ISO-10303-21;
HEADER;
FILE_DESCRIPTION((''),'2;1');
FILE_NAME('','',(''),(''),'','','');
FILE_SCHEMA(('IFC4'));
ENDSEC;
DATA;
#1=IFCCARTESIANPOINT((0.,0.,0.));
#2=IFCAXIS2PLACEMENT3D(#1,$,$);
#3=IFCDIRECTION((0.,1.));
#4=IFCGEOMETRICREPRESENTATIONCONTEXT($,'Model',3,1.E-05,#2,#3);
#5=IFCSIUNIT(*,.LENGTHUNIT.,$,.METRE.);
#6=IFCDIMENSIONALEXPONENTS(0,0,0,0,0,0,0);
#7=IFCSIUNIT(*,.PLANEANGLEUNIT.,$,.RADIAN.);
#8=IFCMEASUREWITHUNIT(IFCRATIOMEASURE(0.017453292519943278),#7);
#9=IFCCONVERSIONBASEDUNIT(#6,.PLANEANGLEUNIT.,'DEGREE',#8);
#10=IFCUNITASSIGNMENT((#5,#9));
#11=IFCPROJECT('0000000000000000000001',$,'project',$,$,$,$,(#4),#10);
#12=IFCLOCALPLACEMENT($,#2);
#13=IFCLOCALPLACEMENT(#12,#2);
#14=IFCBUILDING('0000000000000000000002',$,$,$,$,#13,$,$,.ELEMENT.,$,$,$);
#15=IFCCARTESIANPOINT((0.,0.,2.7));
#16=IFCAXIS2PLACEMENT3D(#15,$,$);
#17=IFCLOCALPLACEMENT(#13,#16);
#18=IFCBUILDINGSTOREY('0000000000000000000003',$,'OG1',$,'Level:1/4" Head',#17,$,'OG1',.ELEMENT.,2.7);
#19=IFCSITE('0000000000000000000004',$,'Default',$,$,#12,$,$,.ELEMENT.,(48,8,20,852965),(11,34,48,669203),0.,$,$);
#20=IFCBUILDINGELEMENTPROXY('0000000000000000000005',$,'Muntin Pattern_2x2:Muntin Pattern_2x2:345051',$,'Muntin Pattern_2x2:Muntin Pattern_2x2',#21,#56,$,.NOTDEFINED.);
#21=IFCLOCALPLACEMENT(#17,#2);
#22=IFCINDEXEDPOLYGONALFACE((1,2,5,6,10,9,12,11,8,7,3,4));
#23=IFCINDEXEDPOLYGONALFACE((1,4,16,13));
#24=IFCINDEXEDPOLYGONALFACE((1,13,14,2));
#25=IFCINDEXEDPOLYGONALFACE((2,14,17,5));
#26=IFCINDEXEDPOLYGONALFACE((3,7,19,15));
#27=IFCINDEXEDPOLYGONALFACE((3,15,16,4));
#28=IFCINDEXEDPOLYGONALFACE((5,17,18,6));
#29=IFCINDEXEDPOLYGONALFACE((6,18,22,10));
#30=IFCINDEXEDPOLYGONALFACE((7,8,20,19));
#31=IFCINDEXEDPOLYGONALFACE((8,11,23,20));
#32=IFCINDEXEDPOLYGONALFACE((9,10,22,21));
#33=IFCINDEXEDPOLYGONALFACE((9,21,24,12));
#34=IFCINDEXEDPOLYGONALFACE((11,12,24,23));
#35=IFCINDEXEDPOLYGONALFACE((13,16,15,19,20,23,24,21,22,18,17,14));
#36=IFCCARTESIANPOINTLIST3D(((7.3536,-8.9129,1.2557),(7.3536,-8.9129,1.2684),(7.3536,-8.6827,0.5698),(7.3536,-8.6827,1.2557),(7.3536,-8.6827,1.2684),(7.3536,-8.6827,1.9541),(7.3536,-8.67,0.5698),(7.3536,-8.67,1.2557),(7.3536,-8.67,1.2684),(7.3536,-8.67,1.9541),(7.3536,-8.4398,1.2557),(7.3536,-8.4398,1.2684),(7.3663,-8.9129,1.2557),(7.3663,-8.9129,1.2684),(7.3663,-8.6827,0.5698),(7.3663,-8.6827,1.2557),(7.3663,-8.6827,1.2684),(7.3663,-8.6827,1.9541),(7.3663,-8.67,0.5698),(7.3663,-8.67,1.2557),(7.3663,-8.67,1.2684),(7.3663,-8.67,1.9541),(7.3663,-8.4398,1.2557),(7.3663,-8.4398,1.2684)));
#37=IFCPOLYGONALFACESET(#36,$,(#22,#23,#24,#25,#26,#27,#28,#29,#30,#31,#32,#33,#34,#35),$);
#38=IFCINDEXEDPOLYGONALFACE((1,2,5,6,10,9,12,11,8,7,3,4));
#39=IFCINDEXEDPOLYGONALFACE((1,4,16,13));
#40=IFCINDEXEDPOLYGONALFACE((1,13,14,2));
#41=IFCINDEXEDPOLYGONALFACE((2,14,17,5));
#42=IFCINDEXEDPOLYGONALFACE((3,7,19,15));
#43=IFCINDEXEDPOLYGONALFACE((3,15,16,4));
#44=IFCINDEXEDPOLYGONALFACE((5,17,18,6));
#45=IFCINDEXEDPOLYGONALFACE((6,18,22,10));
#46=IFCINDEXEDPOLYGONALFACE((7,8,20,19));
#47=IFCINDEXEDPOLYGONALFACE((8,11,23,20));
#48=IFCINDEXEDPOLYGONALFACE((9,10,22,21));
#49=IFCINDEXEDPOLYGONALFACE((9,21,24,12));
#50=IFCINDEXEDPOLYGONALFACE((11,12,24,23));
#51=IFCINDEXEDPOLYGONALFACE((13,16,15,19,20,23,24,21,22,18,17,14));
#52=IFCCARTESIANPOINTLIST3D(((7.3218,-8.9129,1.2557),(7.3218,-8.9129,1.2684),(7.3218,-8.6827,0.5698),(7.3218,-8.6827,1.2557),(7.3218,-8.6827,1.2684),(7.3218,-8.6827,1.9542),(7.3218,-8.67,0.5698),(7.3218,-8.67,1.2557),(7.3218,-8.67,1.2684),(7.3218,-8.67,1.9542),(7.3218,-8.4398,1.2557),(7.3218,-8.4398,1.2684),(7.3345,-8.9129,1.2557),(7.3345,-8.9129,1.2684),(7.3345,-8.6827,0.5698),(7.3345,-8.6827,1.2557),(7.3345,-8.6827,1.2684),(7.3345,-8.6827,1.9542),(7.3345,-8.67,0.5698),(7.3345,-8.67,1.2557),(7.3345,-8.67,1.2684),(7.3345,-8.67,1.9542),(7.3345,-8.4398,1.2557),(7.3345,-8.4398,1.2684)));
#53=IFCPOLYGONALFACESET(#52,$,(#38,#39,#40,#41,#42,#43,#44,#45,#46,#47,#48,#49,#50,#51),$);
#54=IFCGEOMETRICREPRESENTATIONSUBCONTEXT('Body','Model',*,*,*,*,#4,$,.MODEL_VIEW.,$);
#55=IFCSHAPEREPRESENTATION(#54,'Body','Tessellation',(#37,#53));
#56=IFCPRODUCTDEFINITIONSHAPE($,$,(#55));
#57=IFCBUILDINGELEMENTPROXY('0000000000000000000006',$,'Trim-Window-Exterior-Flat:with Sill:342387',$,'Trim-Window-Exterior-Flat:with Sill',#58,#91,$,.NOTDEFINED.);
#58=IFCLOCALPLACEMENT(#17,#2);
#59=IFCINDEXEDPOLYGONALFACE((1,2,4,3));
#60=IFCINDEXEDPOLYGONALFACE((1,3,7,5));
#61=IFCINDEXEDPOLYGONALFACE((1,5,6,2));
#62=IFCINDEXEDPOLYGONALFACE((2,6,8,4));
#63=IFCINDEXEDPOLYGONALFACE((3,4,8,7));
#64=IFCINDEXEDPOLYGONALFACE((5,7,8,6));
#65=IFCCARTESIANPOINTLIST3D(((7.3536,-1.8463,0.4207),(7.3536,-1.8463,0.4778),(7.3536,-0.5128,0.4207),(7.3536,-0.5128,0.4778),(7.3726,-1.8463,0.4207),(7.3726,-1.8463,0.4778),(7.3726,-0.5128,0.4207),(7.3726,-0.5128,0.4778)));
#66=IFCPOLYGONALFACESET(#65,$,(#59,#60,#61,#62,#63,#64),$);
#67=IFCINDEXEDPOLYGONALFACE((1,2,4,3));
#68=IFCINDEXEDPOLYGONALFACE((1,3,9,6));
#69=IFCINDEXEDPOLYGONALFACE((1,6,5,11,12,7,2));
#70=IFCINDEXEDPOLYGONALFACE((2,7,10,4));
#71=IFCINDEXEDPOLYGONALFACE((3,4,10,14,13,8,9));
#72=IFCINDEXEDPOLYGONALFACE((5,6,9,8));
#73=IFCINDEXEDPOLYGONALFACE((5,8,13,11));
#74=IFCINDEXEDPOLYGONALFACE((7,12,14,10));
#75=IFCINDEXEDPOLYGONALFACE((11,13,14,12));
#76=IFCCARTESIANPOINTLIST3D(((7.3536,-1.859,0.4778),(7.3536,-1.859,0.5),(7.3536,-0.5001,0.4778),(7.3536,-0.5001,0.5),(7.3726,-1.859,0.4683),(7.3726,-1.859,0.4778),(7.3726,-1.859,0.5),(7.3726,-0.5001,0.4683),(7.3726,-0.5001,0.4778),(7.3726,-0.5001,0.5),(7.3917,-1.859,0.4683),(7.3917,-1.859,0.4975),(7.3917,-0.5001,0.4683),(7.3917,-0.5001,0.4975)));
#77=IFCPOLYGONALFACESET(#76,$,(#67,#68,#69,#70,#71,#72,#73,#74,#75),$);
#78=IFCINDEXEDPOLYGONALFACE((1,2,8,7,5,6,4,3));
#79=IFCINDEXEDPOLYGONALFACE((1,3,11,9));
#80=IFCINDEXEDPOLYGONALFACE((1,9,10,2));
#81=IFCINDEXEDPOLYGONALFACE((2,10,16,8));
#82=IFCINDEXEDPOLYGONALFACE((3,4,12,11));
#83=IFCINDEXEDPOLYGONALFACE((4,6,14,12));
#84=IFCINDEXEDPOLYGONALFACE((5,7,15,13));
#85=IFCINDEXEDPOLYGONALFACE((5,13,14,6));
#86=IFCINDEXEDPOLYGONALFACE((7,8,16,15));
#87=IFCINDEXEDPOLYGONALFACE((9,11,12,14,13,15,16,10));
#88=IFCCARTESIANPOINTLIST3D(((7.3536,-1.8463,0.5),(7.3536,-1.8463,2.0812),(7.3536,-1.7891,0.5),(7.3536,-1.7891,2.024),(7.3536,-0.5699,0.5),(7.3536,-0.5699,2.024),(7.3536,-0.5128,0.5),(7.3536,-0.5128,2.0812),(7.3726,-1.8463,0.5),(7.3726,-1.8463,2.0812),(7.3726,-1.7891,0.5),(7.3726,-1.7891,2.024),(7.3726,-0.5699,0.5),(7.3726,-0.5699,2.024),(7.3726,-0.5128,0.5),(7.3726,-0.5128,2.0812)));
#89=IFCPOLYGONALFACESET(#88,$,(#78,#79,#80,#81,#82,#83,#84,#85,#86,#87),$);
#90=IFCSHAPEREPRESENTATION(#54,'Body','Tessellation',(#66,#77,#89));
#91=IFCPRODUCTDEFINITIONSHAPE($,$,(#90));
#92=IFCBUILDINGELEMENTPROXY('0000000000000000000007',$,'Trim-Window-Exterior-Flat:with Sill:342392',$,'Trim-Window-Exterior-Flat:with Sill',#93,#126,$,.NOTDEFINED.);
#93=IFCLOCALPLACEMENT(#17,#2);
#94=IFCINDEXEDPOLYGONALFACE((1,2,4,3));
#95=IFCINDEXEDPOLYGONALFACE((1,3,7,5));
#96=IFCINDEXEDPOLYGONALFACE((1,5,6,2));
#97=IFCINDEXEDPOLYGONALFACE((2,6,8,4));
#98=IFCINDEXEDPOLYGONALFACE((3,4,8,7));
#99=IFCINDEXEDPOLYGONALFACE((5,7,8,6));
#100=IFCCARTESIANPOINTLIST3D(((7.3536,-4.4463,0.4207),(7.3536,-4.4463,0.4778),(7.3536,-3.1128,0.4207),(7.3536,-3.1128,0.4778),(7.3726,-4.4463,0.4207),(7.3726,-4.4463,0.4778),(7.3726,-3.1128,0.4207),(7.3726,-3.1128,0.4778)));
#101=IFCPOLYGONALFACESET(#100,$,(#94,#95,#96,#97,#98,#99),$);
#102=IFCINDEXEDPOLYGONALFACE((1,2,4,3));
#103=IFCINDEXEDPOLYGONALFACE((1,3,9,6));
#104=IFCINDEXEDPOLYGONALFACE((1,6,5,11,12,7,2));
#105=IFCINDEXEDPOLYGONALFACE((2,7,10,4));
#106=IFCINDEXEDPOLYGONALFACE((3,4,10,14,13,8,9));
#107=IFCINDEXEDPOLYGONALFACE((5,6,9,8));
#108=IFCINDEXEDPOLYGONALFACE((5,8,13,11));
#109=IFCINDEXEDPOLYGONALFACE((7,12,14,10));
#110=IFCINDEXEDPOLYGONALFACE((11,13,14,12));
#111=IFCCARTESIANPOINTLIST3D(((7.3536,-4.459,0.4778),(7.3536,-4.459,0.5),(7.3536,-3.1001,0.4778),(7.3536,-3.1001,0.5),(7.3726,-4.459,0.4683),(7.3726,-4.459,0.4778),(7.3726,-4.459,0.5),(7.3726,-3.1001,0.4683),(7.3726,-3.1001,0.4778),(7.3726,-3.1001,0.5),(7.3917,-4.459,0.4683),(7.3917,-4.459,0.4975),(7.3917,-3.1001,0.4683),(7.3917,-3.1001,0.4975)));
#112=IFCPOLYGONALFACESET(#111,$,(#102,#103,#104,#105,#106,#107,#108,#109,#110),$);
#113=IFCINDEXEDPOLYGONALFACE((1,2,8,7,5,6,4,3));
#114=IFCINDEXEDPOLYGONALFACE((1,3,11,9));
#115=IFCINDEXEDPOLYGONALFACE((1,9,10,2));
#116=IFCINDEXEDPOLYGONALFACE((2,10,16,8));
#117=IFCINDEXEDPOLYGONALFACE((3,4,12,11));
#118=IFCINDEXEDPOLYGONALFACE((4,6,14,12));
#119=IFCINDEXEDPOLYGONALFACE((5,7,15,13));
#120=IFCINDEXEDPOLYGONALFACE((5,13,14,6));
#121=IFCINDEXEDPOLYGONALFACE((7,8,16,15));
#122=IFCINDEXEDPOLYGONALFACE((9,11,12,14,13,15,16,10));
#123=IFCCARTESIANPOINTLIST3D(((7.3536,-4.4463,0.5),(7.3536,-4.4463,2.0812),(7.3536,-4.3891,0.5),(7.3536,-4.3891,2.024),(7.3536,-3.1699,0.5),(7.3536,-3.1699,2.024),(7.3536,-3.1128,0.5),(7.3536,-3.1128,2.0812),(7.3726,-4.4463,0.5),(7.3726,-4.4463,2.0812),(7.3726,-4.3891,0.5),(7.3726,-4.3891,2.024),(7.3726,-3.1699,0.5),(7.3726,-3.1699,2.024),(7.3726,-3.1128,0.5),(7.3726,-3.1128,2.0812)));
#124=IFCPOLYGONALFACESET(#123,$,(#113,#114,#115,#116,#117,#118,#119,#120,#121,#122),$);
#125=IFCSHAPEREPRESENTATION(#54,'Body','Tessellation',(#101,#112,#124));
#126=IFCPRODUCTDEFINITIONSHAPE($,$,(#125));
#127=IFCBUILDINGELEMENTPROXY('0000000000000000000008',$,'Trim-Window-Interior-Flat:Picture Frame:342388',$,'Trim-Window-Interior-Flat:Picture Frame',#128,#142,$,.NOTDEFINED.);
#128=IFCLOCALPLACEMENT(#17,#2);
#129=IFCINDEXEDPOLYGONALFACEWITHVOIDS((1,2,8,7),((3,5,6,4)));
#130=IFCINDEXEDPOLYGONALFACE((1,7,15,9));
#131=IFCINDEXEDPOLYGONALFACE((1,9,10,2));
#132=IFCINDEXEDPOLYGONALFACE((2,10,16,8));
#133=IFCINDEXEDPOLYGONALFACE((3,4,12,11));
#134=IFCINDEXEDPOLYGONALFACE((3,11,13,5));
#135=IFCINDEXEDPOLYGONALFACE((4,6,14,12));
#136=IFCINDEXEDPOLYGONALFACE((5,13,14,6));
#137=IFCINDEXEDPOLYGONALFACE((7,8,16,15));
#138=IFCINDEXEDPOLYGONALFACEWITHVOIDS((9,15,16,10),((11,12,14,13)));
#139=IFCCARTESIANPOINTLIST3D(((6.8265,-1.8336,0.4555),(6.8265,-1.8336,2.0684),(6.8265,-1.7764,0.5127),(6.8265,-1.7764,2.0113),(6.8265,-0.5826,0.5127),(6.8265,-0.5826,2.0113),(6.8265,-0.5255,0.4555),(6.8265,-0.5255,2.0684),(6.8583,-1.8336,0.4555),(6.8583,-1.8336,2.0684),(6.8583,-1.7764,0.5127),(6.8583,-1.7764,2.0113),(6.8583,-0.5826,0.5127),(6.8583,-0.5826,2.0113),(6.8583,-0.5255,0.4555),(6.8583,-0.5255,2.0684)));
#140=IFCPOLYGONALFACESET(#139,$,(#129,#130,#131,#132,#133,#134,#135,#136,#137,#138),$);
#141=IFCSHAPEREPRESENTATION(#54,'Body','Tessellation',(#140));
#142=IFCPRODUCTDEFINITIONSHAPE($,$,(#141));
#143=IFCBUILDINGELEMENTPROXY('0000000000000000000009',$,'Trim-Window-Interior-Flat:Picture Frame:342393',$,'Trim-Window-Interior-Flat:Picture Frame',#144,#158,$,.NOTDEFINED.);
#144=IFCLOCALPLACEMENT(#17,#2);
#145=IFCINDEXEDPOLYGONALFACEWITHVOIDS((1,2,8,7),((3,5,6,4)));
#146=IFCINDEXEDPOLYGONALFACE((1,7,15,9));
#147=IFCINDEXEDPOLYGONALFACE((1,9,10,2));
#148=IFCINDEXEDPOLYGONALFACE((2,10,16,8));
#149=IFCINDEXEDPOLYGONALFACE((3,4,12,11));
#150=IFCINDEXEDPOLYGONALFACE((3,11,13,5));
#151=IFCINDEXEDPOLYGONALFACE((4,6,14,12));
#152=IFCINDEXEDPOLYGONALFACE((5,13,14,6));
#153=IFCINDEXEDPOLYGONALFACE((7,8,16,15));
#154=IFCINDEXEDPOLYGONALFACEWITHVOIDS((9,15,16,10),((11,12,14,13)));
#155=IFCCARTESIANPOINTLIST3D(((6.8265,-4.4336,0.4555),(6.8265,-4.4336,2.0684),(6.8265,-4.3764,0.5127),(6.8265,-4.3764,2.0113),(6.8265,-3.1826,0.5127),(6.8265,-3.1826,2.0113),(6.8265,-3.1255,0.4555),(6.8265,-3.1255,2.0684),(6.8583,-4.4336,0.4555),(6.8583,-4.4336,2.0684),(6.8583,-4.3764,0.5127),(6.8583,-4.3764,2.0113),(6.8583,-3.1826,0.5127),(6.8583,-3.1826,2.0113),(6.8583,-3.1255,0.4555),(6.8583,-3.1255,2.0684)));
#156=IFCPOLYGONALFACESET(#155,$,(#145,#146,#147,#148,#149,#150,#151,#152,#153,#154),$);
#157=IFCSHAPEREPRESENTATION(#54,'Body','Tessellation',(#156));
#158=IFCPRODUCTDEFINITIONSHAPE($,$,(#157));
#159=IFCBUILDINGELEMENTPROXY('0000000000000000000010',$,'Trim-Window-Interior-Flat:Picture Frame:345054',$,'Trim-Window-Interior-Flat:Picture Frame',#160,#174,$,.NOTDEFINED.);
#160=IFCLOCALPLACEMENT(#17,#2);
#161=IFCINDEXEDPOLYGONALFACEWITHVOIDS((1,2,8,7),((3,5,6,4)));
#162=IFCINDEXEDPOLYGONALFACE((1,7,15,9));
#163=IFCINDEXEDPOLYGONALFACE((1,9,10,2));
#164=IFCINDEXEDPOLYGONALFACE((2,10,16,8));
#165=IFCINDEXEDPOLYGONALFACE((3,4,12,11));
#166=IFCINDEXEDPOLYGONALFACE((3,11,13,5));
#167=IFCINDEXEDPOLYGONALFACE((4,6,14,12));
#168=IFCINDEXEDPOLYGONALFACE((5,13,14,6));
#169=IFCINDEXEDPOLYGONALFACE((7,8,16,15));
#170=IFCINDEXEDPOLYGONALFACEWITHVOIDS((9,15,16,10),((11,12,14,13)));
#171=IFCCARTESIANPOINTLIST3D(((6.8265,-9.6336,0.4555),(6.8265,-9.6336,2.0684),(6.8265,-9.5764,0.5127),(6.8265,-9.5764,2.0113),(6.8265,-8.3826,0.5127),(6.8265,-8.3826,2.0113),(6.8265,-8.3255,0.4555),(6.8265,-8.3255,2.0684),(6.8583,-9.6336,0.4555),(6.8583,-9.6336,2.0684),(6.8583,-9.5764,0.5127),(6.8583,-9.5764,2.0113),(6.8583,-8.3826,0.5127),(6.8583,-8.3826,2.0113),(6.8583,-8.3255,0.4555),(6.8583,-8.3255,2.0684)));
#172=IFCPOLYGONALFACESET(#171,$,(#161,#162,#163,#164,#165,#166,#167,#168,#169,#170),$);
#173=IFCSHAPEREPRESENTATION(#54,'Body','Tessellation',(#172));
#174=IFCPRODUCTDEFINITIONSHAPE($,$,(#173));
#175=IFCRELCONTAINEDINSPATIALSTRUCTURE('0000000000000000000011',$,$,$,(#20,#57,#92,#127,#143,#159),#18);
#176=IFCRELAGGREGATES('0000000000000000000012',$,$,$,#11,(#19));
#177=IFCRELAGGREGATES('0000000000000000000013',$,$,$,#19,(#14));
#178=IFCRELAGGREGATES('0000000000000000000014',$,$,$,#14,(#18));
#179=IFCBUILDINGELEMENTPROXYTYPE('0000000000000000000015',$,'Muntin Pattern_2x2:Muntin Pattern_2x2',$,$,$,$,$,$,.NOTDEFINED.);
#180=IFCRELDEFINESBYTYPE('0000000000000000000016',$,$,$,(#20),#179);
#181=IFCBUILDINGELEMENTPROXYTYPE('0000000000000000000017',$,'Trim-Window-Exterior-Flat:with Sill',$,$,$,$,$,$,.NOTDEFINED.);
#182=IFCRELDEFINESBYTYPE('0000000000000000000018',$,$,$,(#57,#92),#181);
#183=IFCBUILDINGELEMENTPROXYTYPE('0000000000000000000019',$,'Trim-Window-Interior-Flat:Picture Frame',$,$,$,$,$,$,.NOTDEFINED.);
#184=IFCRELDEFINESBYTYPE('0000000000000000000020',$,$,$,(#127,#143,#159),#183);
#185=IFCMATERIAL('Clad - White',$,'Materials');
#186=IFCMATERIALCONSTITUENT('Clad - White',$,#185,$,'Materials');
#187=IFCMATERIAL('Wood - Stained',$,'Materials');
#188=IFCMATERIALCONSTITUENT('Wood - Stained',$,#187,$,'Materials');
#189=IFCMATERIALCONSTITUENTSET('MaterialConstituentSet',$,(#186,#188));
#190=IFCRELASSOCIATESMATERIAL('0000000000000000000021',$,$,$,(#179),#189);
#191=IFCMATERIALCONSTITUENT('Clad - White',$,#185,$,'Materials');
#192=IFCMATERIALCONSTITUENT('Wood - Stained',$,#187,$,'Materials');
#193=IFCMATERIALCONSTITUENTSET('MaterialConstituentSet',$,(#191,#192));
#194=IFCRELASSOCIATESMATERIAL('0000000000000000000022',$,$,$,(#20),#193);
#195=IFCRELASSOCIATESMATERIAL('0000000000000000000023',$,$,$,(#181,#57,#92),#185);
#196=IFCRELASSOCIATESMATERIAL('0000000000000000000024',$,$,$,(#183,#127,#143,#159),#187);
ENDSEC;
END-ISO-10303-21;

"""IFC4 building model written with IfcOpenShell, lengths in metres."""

from ifc_helpers import new_model, entity, si_unit, converted_unit, direction, frame, origin, place, context, subcontext, project, spatial, indexed_curve, outline, extrude, source, transform, mapped, material, constituent, constituent_set, type_object, type_shapes, element, save


model = new_model("IFC4")

# Units and contexts
model_context = context("Model", 3, precision=1e-05, world=origin(), true_north=direction((0.0, 1.0)))
body_context = subcontext(model_context, "Body", "Model", "MODEL_VIEW")
ifc_project = project(units=[si_unit("LENGTHUNIT", "METRE"), converted_unit("PLANEANGLEUNIT", "DEGREE", entity("IfcRatioMeasure", 0.017453292519943278), si_unit("PLANEANGLEUNIT", "RADIAN"), dimensions=[0, 0, 0, 0, 0, 0, 0])], contexts=[model_context])

# Site, building, storey
site_placement = place(None, origin())
site = spatial("IfcSite", under=ifc_project, at=site_placement, Name="Default", CompositionType="ELEMENT", RefLatitude=(48, 8, 20, 852965), RefLongitude=(11, 34, 48, 669203), RefElevation=0.0)
building_placement = place(site_placement, origin())
building = spatial("IfcBuilding", under=site, at=building_placement, CompositionType="ELEMENT")
storey_placement = place(building_placement, frame((0.0, 0.0, 2.7)))
storey = spatial("IfcBuildingStorey", under=building, at=storey_placement, Name="OG1", ObjectType="Level:1/4\" Head", LongName="OG1", CompositionType="ELEMENT", Elevation=2.7)

# Building element proxies
ifc_material_1 = material(Name="Clad - White", Category="Materials")
ifc_material_2 = material(Name="Wood - Stained", Category="Materials")
ifc_constituent_1 = constituent(ifc_material_1, Name="Clad - White", Category="Materials")
ifc_constituent_2 = constituent(ifc_material_2, Name="Wood - Stained", Category="Materials")
ifc_constituent_set_1 = constituent_set(constituents=[ifc_constituent_1, ifc_constituent_2], Name="MaterialConstituentSet")
building_element_proxy_type_1 = type_object("IfcBuildingElementProxyType", Name="Muntin Pattern_2x2:Muntin Pattern_2x2", PredefinedType="NOTDEFINED", material=ifc_constituent_set_1)
shared_shape_1 = source(origin(), body_context, "Body", "SweptSolid", [
    extrude(outline(indexed_curve([(0.0064, -0.0064), (0.6921, -0.0064), (0.6921, 0.0063), (0.0064, 0.0063), (0.0064, 0.2365), (-0.0063, 0.2365), (-0.0063, 0.0063), (-0.6922, 0.0063), (-0.6922, -0.0064), (-0.0063, -0.0064), (-0.0063, -0.2365), (0.0064, -0.2365), (0.0064, -0.0064)], self_intersect=False)), frame((0.0, 0.0095, 0.6921), z_axis=(0.0, 1.0, 0.0), x_axis=(0.0, 0.0, 1.0)), (0.0, 0.0, 1.0), 0.0127),
    extrude(outline(indexed_curve([(0.0064, -0.0064), (0.6922, -0.0064), (0.6922, 0.0063), (0.0064, 0.0063), (0.0064, 0.2365), (-0.0063, 0.2365), (-0.0063, 0.0063), (-0.6922, 0.0063), (-0.6922, -0.0064), (-0.0063, -0.0064), (-0.0063, -0.2365), (0.0064, -0.2365), (0.0064, -0.0064)], self_intersect=False)), frame((0.0, -0.0222, 0.6922), z_axis=(0.0, 1.0, 0.0), x_axis=(0.0, 0.0, 1.0)), (0.0, 0.0, 1.0), 0.0127),
])
type_shapes(building_element_proxy_type_1, [shared_shape_1])
ifc_constituent_3 = constituent(ifc_material_1, Name="Clad - White", Category="Materials")
ifc_constituent_4 = constituent(ifc_material_2, Name="Wood - Stained", Category="Materials")
ifc_constituent_set_2 = constituent_set(constituents=[ifc_constituent_3, ifc_constituent_4], Name="MaterialConstituentSet")
proxy_1_placement = place(storey_placement, frame((7.3441, -8.6763, 0.5699), z_axis=(0.0, 0.0, 1.0), x_axis=(0.0, -1.0, 0.0)))
element("IfcBuildingElementProxy", 1, at=proxy_1_placement, inside=storey, type_object=building_element_proxy_type_1, material=ifc_constituent_set_2, Name="Muntin Pattern_2x2:Muntin Pattern_2x2:345051", ObjectType="Muntin Pattern_2x2:Muntin Pattern_2x2", PredefinedType="NOTDEFINED", context=body_context, shape_type="MappedRepresentation", body=[
    mapped(shared_shape_1, transform((0.0, 0.0, 0.0), scale=1.0)),
])
building_element_proxy_type_2 = type_object("IfcBuildingElementProxyType", Name="Trim-Window-Exterior-Flat:with Sill", PredefinedType="NOTDEFINED", material=ifc_material_1)
shared_shape_2 = source(origin(), body_context, "Body", "SweptSolid", [
    extrude(outline(indexed_curve([(-0.6667, -0.0286), (0.6667, -0.0286), (0.6667, 0.0286), (-0.6667, 0.0286), (-0.6667, -0.0286)], self_intersect=False)), frame((0.0, -1.5748, 0.0), z_axis=(0.0, 0.0, 1.0), x_axis=(-1.0, 0.0, 0.0)), (0.0, 0.0, 1.0), 0.019),
    extrude(outline(indexed_curve([(-0.019, -0.016), (0.0, -0.016), (0.0, -0.0064), (0.019, -0.0064), (0.019, 0.0158), (0.0, 0.0158), (-0.019, 0.0133), (-0.019, -0.016)], self_intersect=False)), frame((-0.6794, -1.5398, 0.019), z_axis=(1.0, 0.0, 0.0), x_axis=(0.0, 0.0, -1.0)), (0.0, 0.0, 1.0), 1.3589),
    extrude(outline(indexed_curve([(-0.8049, -0.6667), (0.7763, -0.6667), (0.7763, -0.6096), (-0.7477, -0.6096), (-0.7477, 0.6096), (0.7763, 0.6096), (0.7763, 0.6667), (-0.8049, 0.6667), (-0.8049, -0.6667)], self_intersect=False)), frame((0.0, -0.7477, 0.0), z_axis=(0.0, 0.0, 1.0), x_axis=(0.0, -1.0, 0.0)), (0.0, 0.0, 1.0), 0.019),
])
type_shapes(building_element_proxy_type_2, [shared_shape_2])
for number, where, z_axis, x_axis, name in (
    (2, (7.3536, -1.1795, 2.024), (1.0, 0.0, 0.0), (0.0, 1.0, 0.0), "Trim-Window-Exterior-Flat:with Sill:342387"),
    (3, (7.3536, -3.7795, 2.024), (1.0, 0.0, 0.0), (0.0, 1.0, 0.0), "Trim-Window-Exterior-Flat:with Sill:342392"),
):
    element("IfcBuildingElementProxy", number, at=place(storey_placement, frame(where, z_axis=z_axis, x_axis=x_axis)), inside=storey, type_object=building_element_proxy_type_2, material=ifc_material_1, Name=name, ObjectType="Trim-Window-Exterior-Flat:with Sill", PredefinedType="NOTDEFINED", context=body_context, shape_type="MappedRepresentation", body=[
        mapped(shared_shape_2, transform((0.0, 0.0, 0.0), scale=1.0)),
    ])
building_element_proxy_type_3 = type_object("IfcBuildingElementProxyType", Name="Trim-Window-Interior-Flat:Picture Frame", PredefinedType="NOTDEFINED", material=ifc_material_2)
shared_shape_3 = source(origin(), body_context, "Body", "SweptSolid", [
    extrude(outline(indexed_curve([(-0.654, -0.8064), (0.654, -0.8064), (0.654, 0.8064), (-0.654, 0.8064), (-0.654, -0.8064)], self_intersect=False), holes=[indexed_curve([(-0.5969, -0.7493), (-0.5969, 0.7493), (0.5969, 0.7493), (0.5969, -0.7493), (-0.5969, -0.7493)], self_intersect=False)]), frame((0.0, -0.762, 0.0), z_axis=(0.0, 0.0, 1.0), x_axis=(-1.0, 0.0, 0.0)), (0.0, 0.0, 1.0), 0.0317),
])
type_shapes(building_element_proxy_type_3, [shared_shape_3])
for number, where, z_axis, x_axis, name in (
    (4, (6.8583, -1.1795, 2.024), (-1.0, 0.0, 0.0), (0.0, -1.0, 0.0), "Trim-Window-Interior-Flat:Picture Frame:342388"),
    (5, (6.8583, -3.7795, 2.024), (-1.0, 0.0, 0.0), (0.0, -1.0, 0.0), "Trim-Window-Interior-Flat:Picture Frame:342393"),
    (6, (6.8583, -8.9795, 2.024), (-1.0, 0.0, 0.0), (0.0, -1.0, 0.0), "Trim-Window-Interior-Flat:Picture Frame:345054"),
):
    element("IfcBuildingElementProxy", number, at=place(storey_placement, frame(where, z_axis=z_axis, x_axis=x_axis)), inside=storey, type_object=building_element_proxy_type_3, material=ifc_material_2, Name=name, ObjectType="Trim-Window-Interior-Flat:Picture Frame", PredefinedType="NOTDEFINED", context=body_context, shape_type="MappedRepresentation", body=[
        mapped(shared_shape_3, transform((0.0, 0.0, 0.0), scale=1.0)),
    ])

save(model, "model.ifc")
